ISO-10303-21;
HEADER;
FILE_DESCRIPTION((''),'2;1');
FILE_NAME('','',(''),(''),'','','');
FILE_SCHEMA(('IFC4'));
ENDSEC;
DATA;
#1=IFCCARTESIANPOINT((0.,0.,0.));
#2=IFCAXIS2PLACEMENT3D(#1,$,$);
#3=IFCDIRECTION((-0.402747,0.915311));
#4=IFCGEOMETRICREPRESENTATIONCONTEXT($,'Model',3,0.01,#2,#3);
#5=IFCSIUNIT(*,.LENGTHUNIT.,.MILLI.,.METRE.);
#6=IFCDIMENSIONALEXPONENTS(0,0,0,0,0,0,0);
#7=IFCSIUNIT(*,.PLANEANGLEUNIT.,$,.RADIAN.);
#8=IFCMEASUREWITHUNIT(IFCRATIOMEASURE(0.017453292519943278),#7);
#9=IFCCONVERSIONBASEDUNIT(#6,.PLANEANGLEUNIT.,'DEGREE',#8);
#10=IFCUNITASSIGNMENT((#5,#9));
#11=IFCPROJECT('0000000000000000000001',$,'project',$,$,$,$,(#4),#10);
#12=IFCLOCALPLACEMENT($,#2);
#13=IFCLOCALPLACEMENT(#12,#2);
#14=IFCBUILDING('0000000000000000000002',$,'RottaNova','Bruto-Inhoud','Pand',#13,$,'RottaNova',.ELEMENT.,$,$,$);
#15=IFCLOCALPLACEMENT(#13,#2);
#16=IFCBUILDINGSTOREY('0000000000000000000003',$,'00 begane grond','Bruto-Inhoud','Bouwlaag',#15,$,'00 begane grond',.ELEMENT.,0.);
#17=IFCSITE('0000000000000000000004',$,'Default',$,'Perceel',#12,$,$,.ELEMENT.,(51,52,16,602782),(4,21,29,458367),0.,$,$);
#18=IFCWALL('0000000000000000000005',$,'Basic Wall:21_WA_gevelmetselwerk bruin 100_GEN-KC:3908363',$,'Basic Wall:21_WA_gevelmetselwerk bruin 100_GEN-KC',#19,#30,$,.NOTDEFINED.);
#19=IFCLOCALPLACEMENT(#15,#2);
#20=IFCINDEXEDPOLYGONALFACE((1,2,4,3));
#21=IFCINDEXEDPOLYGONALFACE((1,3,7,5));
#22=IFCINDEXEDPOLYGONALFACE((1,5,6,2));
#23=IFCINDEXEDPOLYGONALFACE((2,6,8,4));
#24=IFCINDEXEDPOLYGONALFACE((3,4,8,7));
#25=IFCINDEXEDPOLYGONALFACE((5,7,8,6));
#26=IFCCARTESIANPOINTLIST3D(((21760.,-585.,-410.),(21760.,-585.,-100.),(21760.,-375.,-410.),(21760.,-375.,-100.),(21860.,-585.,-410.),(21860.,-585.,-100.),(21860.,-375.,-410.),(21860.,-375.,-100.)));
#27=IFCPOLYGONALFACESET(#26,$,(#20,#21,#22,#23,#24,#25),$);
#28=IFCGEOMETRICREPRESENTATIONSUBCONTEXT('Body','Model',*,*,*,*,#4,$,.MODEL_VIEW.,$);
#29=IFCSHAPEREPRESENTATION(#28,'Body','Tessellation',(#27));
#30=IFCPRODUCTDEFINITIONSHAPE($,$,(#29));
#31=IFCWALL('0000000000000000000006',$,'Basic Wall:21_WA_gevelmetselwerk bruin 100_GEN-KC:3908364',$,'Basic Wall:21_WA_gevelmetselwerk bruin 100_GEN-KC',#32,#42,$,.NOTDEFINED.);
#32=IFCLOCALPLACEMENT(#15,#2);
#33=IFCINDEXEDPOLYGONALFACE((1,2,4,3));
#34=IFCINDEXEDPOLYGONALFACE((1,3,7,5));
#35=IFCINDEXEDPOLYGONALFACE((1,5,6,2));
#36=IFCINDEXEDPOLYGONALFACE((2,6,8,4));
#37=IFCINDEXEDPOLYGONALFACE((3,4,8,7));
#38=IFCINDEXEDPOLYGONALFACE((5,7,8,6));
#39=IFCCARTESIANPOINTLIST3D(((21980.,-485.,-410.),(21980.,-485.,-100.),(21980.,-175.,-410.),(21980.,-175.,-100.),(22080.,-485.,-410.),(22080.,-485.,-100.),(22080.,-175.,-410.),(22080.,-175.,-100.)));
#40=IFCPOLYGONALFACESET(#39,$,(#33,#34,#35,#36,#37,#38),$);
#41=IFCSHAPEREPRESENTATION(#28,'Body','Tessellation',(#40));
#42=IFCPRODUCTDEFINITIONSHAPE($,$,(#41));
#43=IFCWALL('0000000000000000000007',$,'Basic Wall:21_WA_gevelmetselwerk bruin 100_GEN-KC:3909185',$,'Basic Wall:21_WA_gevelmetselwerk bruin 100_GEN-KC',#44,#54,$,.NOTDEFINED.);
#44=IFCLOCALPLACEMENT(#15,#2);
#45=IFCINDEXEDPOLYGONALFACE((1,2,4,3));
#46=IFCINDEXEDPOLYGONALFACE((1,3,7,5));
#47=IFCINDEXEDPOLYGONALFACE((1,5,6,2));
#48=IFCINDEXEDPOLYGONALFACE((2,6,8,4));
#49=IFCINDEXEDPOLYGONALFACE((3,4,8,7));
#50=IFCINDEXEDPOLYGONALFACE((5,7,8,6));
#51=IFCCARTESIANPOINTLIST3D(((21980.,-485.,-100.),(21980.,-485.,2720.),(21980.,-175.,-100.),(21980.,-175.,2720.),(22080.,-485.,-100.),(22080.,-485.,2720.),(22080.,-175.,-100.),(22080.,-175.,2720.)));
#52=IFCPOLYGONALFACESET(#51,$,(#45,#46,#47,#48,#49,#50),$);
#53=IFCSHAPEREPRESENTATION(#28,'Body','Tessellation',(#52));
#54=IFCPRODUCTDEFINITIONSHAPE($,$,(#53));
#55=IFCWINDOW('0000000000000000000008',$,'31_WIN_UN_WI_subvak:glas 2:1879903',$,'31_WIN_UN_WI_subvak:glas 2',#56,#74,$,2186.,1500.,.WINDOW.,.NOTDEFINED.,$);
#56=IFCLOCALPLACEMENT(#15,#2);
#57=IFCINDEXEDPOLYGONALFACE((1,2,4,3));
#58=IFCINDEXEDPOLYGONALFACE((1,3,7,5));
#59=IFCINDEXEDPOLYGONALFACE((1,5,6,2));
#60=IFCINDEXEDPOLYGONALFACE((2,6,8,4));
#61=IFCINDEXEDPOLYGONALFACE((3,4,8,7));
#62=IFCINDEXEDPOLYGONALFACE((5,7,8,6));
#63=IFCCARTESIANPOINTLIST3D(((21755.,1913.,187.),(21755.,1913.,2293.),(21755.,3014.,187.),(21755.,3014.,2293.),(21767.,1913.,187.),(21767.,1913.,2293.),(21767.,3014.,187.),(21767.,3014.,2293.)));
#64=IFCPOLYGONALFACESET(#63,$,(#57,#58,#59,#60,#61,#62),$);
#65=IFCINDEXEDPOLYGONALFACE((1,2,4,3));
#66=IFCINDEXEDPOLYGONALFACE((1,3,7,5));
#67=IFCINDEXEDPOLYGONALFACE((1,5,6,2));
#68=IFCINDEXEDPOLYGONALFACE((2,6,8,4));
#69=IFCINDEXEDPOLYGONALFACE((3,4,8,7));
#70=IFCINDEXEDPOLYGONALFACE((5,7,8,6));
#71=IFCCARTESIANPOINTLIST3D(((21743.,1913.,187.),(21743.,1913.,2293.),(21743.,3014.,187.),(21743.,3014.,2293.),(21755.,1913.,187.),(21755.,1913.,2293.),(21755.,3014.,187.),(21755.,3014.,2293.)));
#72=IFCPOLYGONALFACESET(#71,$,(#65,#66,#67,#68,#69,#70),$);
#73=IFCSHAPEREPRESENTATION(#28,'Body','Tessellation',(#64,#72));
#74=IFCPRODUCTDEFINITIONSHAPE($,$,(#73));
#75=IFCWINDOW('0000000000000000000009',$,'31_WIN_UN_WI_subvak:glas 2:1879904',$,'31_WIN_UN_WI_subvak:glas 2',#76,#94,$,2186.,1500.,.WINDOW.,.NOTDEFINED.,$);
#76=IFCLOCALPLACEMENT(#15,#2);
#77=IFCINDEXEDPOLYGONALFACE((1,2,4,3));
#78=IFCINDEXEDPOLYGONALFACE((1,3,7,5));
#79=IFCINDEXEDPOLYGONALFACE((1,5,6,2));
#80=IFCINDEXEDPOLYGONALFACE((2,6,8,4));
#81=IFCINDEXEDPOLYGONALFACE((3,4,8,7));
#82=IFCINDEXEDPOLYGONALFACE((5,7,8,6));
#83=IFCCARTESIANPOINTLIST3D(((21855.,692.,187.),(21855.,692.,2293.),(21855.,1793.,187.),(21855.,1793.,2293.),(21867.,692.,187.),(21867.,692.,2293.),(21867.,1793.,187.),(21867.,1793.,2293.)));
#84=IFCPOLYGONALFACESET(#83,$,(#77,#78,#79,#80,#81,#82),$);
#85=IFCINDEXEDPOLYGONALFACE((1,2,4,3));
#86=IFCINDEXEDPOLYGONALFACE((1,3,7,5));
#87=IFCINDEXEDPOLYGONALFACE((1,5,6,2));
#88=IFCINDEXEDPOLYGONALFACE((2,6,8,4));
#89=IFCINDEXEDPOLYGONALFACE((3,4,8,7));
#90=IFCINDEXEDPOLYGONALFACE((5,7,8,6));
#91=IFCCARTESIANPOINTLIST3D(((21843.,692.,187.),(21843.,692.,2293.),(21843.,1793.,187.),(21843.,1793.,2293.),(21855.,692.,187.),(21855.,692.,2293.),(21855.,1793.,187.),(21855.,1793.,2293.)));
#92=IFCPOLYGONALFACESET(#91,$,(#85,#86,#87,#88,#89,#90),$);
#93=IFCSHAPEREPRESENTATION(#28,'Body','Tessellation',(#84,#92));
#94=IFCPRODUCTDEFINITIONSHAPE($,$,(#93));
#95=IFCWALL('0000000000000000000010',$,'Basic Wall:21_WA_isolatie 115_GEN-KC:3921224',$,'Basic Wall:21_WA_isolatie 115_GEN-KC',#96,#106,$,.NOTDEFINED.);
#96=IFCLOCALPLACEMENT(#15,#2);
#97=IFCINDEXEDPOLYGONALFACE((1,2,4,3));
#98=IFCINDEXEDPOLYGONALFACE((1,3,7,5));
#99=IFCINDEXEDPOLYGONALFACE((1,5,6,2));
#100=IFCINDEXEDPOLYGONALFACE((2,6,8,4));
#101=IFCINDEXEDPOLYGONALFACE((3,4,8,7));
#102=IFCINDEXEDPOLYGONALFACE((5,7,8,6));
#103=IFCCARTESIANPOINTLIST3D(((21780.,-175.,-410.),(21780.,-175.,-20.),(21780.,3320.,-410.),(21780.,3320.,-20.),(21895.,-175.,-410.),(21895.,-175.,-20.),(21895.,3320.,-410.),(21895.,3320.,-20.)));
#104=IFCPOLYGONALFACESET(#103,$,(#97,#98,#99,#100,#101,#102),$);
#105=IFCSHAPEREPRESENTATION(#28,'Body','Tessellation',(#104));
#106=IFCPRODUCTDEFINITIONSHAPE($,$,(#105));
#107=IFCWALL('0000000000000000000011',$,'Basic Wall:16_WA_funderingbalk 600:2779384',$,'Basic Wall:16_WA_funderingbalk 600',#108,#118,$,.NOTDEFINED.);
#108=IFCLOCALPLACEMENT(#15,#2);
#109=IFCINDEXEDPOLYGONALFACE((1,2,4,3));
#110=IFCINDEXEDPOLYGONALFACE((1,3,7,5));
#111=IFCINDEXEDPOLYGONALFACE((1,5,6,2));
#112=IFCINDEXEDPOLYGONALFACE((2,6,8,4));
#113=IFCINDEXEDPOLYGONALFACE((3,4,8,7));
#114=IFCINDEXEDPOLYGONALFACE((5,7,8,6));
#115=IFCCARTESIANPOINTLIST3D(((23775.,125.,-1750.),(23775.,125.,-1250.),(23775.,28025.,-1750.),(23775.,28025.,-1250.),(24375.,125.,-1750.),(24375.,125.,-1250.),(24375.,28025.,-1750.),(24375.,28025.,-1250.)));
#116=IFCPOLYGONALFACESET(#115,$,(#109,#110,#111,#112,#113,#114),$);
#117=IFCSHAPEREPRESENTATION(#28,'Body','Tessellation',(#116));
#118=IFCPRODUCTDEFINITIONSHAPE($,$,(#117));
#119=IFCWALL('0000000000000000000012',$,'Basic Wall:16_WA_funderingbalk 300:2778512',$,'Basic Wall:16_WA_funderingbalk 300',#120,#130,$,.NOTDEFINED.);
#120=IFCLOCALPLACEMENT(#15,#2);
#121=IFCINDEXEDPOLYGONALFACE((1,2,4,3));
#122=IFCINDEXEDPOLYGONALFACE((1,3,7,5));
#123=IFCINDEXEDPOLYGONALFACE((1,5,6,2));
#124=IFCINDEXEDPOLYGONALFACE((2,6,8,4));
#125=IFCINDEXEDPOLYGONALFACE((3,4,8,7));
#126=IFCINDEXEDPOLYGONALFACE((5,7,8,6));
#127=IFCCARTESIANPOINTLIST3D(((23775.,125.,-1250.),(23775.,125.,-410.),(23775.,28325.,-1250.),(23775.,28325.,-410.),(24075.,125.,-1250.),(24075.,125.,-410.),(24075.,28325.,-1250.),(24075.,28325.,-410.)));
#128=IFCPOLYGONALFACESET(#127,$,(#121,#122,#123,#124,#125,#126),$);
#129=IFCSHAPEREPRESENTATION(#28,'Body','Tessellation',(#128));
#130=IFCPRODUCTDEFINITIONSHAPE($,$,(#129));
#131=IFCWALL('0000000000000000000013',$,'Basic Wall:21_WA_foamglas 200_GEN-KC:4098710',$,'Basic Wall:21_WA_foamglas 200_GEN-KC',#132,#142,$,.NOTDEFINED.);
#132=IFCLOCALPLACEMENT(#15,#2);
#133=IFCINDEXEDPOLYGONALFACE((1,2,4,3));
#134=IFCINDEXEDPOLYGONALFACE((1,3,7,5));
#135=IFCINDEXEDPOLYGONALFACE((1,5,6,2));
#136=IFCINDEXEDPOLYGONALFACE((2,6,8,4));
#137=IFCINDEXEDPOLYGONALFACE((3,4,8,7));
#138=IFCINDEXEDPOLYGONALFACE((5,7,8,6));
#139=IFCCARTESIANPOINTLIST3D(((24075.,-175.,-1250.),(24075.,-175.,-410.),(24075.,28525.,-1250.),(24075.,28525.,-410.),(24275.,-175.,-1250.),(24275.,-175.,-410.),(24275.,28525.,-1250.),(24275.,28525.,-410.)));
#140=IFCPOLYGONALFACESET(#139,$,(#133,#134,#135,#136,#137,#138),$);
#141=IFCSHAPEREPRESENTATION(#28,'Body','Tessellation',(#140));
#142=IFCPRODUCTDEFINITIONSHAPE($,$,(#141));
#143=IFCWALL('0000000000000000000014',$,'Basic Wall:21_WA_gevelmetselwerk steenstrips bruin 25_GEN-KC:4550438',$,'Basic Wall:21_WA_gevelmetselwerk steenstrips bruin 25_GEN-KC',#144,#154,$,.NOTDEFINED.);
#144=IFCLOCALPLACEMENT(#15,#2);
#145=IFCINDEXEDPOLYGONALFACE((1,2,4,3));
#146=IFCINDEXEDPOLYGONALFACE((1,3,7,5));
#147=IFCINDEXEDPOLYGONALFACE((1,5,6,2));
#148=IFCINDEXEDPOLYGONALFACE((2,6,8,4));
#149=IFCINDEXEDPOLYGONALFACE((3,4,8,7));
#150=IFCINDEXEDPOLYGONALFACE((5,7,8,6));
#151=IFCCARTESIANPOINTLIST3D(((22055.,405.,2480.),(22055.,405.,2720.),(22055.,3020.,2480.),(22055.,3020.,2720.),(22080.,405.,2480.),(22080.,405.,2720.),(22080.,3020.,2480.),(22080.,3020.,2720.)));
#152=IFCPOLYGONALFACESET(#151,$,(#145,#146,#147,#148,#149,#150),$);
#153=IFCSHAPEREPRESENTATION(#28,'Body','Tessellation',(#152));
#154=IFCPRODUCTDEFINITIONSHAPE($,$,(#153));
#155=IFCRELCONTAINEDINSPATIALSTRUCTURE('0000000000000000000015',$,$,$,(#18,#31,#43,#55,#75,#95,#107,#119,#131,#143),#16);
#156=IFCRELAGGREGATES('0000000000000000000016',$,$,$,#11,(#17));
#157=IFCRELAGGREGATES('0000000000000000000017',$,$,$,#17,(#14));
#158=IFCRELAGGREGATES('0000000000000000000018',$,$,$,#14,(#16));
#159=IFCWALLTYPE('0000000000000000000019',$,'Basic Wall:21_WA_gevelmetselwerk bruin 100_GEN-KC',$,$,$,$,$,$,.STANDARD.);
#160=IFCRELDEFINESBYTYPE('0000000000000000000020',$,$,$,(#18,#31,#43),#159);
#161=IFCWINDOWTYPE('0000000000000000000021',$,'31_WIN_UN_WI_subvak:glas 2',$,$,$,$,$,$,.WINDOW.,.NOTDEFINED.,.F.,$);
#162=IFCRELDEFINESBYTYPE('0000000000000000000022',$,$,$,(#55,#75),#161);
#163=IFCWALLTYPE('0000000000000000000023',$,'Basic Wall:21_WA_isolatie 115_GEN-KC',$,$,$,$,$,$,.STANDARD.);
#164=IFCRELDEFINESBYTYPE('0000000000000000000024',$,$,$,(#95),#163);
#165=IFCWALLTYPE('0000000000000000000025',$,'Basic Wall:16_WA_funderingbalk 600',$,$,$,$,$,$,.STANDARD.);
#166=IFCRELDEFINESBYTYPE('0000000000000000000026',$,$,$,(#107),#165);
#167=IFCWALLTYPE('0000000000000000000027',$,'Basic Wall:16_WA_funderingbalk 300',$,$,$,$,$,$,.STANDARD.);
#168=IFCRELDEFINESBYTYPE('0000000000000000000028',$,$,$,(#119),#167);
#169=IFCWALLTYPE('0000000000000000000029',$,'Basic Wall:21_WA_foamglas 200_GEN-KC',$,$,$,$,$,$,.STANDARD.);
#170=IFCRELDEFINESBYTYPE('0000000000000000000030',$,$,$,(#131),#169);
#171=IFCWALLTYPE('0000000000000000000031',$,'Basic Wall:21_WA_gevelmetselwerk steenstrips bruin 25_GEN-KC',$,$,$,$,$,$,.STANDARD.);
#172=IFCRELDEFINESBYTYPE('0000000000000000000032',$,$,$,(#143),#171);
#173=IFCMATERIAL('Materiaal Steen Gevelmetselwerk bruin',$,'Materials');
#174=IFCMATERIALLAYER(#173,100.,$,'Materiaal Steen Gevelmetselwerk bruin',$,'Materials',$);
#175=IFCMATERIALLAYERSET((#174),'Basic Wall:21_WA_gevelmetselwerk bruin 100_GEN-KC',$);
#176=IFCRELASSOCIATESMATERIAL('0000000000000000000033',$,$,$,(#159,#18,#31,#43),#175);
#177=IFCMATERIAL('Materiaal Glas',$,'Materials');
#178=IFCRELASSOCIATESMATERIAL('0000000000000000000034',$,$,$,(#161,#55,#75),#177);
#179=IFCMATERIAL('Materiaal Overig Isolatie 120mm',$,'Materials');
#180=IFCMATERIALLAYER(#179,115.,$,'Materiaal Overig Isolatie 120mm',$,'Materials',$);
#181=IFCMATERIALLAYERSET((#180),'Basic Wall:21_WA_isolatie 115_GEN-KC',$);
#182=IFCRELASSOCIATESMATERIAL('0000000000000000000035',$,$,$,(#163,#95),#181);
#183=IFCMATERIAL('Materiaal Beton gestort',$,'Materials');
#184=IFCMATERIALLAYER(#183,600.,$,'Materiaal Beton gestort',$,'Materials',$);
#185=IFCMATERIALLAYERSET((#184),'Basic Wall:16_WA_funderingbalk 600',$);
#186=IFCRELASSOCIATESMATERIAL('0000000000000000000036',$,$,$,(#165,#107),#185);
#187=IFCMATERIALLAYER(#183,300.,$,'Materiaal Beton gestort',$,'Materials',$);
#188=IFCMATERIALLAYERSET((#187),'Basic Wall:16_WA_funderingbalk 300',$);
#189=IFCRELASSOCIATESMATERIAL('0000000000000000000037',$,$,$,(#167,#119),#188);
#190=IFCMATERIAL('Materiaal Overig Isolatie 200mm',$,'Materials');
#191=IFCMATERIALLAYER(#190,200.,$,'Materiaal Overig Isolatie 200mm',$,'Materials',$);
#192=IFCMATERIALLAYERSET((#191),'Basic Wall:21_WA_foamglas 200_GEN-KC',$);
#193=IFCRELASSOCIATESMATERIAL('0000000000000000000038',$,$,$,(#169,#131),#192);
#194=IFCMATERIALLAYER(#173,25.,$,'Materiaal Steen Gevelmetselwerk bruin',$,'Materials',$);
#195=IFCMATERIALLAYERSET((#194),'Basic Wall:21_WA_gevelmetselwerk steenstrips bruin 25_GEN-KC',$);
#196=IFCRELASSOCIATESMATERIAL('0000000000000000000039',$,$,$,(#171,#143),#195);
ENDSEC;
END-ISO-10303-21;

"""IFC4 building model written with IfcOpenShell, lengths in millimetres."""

from ifc_helpers import new_model, entity, si_unit, converted_unit, direction, frame, frame_2d, origin, origin_2d_with_axis, place, context, subcontext, project, spatial, rectangle, extrude, source, transform, mapped, material, layer, layer_set, type_object, type_shapes, element, save


model = new_model("IFC4")

# Units and contexts
model_context = context("Model", 3, precision=0.01, world=origin(), true_north=direction((-0.402747, 0.915311)))
body_context = subcontext(model_context, "Body", "Model", "MODEL_VIEW")
ifc_project = project(units=[si_unit("LENGTHUNIT", "METRE", prefix="MILLI"), converted_unit("PLANEANGLEUNIT", "DEGREE", entity("IfcRatioMeasure", 0.017453292519943278), si_unit("PLANEANGLEUNIT", "RADIAN"), dimensions=[0, 0, 0, 0, 0, 0, 0])], contexts=[model_context])

# Site, building, storey
site_placement = place(None, origin())
site = spatial("IfcSite", under=ifc_project, at=site_placement, Name="Default", ObjectType="Perceel", CompositionType="ELEMENT", RefLatitude=(51, 52, 16, 602782), RefLongitude=(4, 21, 29, 458367), RefElevation=0.0)
building_placement = place(site_placement, origin())
building = spatial("IfcBuilding", under=site, at=building_placement, Name="RottaNova", Description="Bruto-Inhoud", ObjectType="Pand", LongName="RottaNova", CompositionType="ELEMENT")
storey_placement = place(building_placement, origin())
storey = spatial("IfcBuildingStorey", under=building, at=storey_placement, Name="00 begane grond", Description="Bruto-Inhoud", ObjectType="Bouwlaag", LongName="00 begane grond", CompositionType="ELEMENT", Elevation=0.0)

# Walls
ifc_material_1 = material(Name="Materiaal Steen Gevelmetselwerk bruin", Category="Materials")
ifc_layer_1 = layer(ifc_material_1, 100.0, Name="Materiaal Steen Gevelmetselwerk bruin", Category="Materials")
ifc_layer_set_1 = layer_set([ifc_layer_1], Name="Basic Wall:21_WA_gevelmetselwerk bruin 100_GEN-KC")
wall_type_1 = type_object("IfcWallType", Name="Basic Wall:21_WA_gevelmetselwerk bruin 100_GEN-KC", PredefinedType="STANDARD", material=ifc_layer_set_1)
wall_1_placement = place(storey_placement, frame((21810.0, -585.0, -410.0), z_axis=(0.0, 0.0, 1.0), x_axis=(0.0, 1.0, 0.0)))
element("IfcWall", 1, at=wall_1_placement, inside=storey, type_object=wall_type_1, material=ifc_layer_set_1, Name="Basic Wall:21_WA_gevelmetselwerk bruin 100_GEN-KC:3908363", ObjectType="Basic Wall:21_WA_gevelmetselwerk bruin 100_GEN-KC", PredefinedType="NOTDEFINED", context=body_context, shape_type="SweptSolid", body=[
    extrude(rectangle(XDim=210.0, YDim=100.0, at=frame_2d((105.0, 0.0), x_axis=(-1.0, 0.0))), origin(), (0.0, 0.0, 1.0), 310.0),
])
wall_2_placement = place(storey_placement, frame((22030.0, -175.0, -410.0), z_axis=(0.0, 0.0, 1.0), x_axis=(0.0, -1.0, 0.0)))
element("IfcWall", 2, at=wall_2_placement, inside=storey, type_object=wall_type_1, material=ifc_layer_set_1, Name="Basic Wall:21_WA_gevelmetselwerk bruin 100_GEN-KC:3908364", ObjectType="Basic Wall:21_WA_gevelmetselwerk bruin 100_GEN-KC", PredefinedType="NOTDEFINED", context=body_context, shape_type="SweptSolid", body=[
    extrude(rectangle(XDim=310.0, YDim=100.0, at=frame_2d((155.0, 0.0), x_axis=(-1.0, 0.0))), origin(), (0.0, 0.0, 1.0), 310.0),
])
wall_3_placement = place(storey_placement, frame((22030.0, -175.0, -100.0), z_axis=(0.0, 0.0, 1.0), x_axis=(0.0, -1.0, 0.0)))
element("IfcWall", 3, at=wall_3_placement, inside=storey, type_object=wall_type_1, material=ifc_layer_set_1, Name="Basic Wall:21_WA_gevelmetselwerk bruin 100_GEN-KC:3909185", ObjectType="Basic Wall:21_WA_gevelmetselwerk bruin 100_GEN-KC", PredefinedType="NOTDEFINED", context=body_context, shape_type="SweptSolid", body=[
    extrude(rectangle(XDim=310.0, YDim=100.0, at=frame_2d((155.0, 0.0), x_axis=(-1.0, 0.0))), origin(), (0.0, 0.0, 1.0), 2820.0),
])

# Windows
ifc_material_2 = material(Name="Materiaal Glas", Category="Materials")
window_type = type_object("IfcWindowType", Name="31_WIN_UN_WI_subvak:glas 2", ParameterTakesPrecedence=False, PartitioningType="NOTDEFINED", PredefinedType="WINDOW", material=ifc_material_2)
shared_shape_1 = source(origin(), body_context, "Body", "SweptSolid", [
    extrude(rectangle(XDim=1101.0, YDim=12.0, at=origin_2d_with_axis()), frame((0.0, -6.0, 0.0)), (0.0, 0.0, 1.0), 2106.0),
    extrude(rectangle(XDim=1101.0, YDim=12.0, at=origin_2d_with_axis()), frame((0.0, 6.0, 0.0)), (0.0, 0.0, 1.0), 2106.0),
])
type_shapes(window_type, [shared_shape_1])
for number, where, z_axis, x_axis, name in (
    (4, (21755.0, 2463.5, 187.0), (0.0, 0.0, 1.0), (0.0, 1.0, 0.0), "31_WIN_UN_WI_subvak:glas 2:1879903"),
    (5, (21855.0, 1242.5, 187.0), (0.0, 0.0, 1.0), (0.0, 1.0, 0.0), "31_WIN_UN_WI_subvak:glas 2:1879904"),
):
    element("IfcWindow", number, at=place(storey_placement, frame(where, z_axis=z_axis, x_axis=x_axis)), inside=storey, type_object=window_type, material=ifc_material_2, Name=name, ObjectType="31_WIN_UN_WI_subvak:glas 2", OverallHeight=2186.0, OverallWidth=1500.0, PartitioningType="NOTDEFINED", PredefinedType="WINDOW", context=body_context, shape_type="MappedRepresentation", body=[
        mapped(shared_shape_1, transform((0.0, 0.0, 0.0), scale=1.0)),
    ])

# Walls
ifc_material_3 = material(Name="Materiaal Overig Isolatie 120mm", Category="Materials")
ifc_layer_2 = layer(ifc_material_3, 115.0, Name="Materiaal Overig Isolatie 120mm", Category="Materials")
ifc_layer_set_2 = layer_set([ifc_layer_2], Name="Basic Wall:21_WA_isolatie 115_GEN-KC")
wall_type_2 = type_object("IfcWallType", Name="Basic Wall:21_WA_isolatie 115_GEN-KC", PredefinedType="STANDARD", material=ifc_layer_set_2)
wall_4_placement = place(storey_placement, frame((21837.5, -175.0, -410.0), z_axis=(0.0, 0.0, 1.0), x_axis=(0.0, 1.0, 0.0)))
element("IfcWall", 6, at=wall_4_placement, inside=storey, type_object=wall_type_2, material=ifc_layer_set_2, Name="Basic Wall:21_WA_isolatie 115_GEN-KC:3921224", ObjectType="Basic Wall:21_WA_isolatie 115_GEN-KC", PredefinedType="NOTDEFINED", context=body_context, shape_type="SweptSolid", body=[
    extrude(rectangle(XDim=3495.0, YDim=115.0, at=frame_2d((1747.5, 0.0), x_axis=(-1.0, 0.0))), origin(), (0.0, 0.0, 1.0), 390.0),
])
ifc_material_4 = material(Name="Materiaal Beton gestort", Category="Materials")
ifc_layer_3 = layer(ifc_material_4, 600.0, Name="Materiaal Beton gestort", Category="Materials")
ifc_layer_set_3 = layer_set([ifc_layer_3], Name="Basic Wall:16_WA_funderingbalk 600")
wall_type_3 = type_object("IfcWallType", Name="Basic Wall:16_WA_funderingbalk 600", PredefinedType="STANDARD", material=ifc_layer_set_3)
wall_5_placement = place(storey_placement, frame((24075.0, 125.0, -1750.0), z_axis=(0.0, 0.0, 1.0), x_axis=(0.0, 1.0, 0.0)))
element("IfcWall", 7, at=wall_5_placement, inside=storey, type_object=wall_type_3, material=ifc_layer_set_3, Name="Basic Wall:16_WA_funderingbalk 600:2779384", ObjectType="Basic Wall:16_WA_funderingbalk 600", PredefinedType="NOTDEFINED", context=body_context, shape_type="SweptSolid", body=[
    extrude(rectangle(XDim=27900.0, YDim=600.0, at=frame_2d((13950.0, 0.0), x_axis=(-1.0, 0.0))), origin(), (0.0, 0.0, 1.0), 500.0),
])
ifc_layer_4 = layer(ifc_material_4, 300.0, Name="Materiaal Beton gestort", Category="Materials")
ifc_layer_set_4 = layer_set([ifc_layer_4], Name="Basic Wall:16_WA_funderingbalk 300")
wall_type_4 = type_object("IfcWallType", Name="Basic Wall:16_WA_funderingbalk 300", PredefinedType="STANDARD", material=ifc_layer_set_4)
wall_6_placement = place(storey_placement, frame((23925.0, 125.0, -1250.0), z_axis=(0.0, 0.0, 1.0), x_axis=(0.0, 1.0, 0.0)))
element("IfcWall", 8, at=wall_6_placement, inside=storey, type_object=wall_type_4, material=ifc_layer_set_4, Name="Basic Wall:16_WA_funderingbalk 300:2778512", ObjectType="Basic Wall:16_WA_funderingbalk 300", PredefinedType="NOTDEFINED", context=body_context, shape_type="SweptSolid", body=[
    extrude(rectangle(XDim=28200.0, YDim=300.0, at=frame_2d((14100.0, 0.0), x_axis=(-1.0, 0.0))), origin(), (0.0, 0.0, 1.0), 840.0),
])
ifc_material_5 = material(Name="Materiaal Overig Isolatie 200mm", Category="Materials")
ifc_layer_5 = layer(ifc_material_5, 200.0, Name="Materiaal Overig Isolatie 200mm", Category="Materials")
ifc_layer_set_5 = layer_set([ifc_layer_5], Name="Basic Wall:21_WA_foamglas 200_GEN-KC")
wall_type_5 = type_object("IfcWallType", Name="Basic Wall:21_WA_foamglas 200_GEN-KC", PredefinedType="STANDARD", material=ifc_layer_set_5)
wall_7_placement = place(storey_placement, frame((24175.0, -175.0, -1250.0), z_axis=(0.0, 0.0, 1.0), x_axis=(0.0, 1.0, 0.0)))
element("IfcWall", 9, at=wall_7_placement, inside=storey, type_object=wall_type_5, material=ifc_layer_set_5, Name="Basic Wall:21_WA_foamglas 200_GEN-KC:4098710", ObjectType="Basic Wall:21_WA_foamglas 200_GEN-KC", PredefinedType="NOTDEFINED", context=body_context, shape_type="SweptSolid", body=[
    extrude(rectangle(XDim=28700.0, YDim=200.0, at=frame_2d((14350.0, 0.0), x_axis=(-1.0, 0.0))), origin(), (0.0, 0.0, 1.0), 840.0),
])
ifc_layer_6 = layer(ifc_material_1, 25.0, Name="Materiaal Steen Gevelmetselwerk bruin", Category="Materials")
ifc_layer_set_6 = layer_set([ifc_layer_6], Name="Basic Wall:21_WA_gevelmetselwerk steenstrips bruin 25_GEN-KC")
wall_type_6 = type_object("IfcWallType", Name="Basic Wall:21_WA_gevelmetselwerk steenstrips bruin 25_GEN-KC", PredefinedType="STANDARD", material=ifc_layer_set_6)
wall_8_placement = place(storey_placement, frame((22067.5, 405.0, 2480.0), z_axis=(0.0, 0.0, 1.0), x_axis=(0.0, 1.0, 0.0)))
element("IfcWall", 10, at=wall_8_placement, inside=storey, type_object=wall_type_6, material=ifc_layer_set_6, Name="Basic Wall:21_WA_gevelmetselwerk steenstrips bruin 25_GEN-KC:4550438", ObjectType="Basic Wall:21_WA_gevelmetselwerk steenstrips bruin 25_GEN-KC", PredefinedType="NOTDEFINED", context=body_context, shape_type="SweptSolid", body=[
    extrude(rectangle(XDim=2615.0, YDim=25.0, at=frame_2d((1307.5, 0.0), x_axis=(-1.0, 0.0))), origin(), (0.0, 0.0, 1.0), 240.0),
])

save(model, "model.ifc")
